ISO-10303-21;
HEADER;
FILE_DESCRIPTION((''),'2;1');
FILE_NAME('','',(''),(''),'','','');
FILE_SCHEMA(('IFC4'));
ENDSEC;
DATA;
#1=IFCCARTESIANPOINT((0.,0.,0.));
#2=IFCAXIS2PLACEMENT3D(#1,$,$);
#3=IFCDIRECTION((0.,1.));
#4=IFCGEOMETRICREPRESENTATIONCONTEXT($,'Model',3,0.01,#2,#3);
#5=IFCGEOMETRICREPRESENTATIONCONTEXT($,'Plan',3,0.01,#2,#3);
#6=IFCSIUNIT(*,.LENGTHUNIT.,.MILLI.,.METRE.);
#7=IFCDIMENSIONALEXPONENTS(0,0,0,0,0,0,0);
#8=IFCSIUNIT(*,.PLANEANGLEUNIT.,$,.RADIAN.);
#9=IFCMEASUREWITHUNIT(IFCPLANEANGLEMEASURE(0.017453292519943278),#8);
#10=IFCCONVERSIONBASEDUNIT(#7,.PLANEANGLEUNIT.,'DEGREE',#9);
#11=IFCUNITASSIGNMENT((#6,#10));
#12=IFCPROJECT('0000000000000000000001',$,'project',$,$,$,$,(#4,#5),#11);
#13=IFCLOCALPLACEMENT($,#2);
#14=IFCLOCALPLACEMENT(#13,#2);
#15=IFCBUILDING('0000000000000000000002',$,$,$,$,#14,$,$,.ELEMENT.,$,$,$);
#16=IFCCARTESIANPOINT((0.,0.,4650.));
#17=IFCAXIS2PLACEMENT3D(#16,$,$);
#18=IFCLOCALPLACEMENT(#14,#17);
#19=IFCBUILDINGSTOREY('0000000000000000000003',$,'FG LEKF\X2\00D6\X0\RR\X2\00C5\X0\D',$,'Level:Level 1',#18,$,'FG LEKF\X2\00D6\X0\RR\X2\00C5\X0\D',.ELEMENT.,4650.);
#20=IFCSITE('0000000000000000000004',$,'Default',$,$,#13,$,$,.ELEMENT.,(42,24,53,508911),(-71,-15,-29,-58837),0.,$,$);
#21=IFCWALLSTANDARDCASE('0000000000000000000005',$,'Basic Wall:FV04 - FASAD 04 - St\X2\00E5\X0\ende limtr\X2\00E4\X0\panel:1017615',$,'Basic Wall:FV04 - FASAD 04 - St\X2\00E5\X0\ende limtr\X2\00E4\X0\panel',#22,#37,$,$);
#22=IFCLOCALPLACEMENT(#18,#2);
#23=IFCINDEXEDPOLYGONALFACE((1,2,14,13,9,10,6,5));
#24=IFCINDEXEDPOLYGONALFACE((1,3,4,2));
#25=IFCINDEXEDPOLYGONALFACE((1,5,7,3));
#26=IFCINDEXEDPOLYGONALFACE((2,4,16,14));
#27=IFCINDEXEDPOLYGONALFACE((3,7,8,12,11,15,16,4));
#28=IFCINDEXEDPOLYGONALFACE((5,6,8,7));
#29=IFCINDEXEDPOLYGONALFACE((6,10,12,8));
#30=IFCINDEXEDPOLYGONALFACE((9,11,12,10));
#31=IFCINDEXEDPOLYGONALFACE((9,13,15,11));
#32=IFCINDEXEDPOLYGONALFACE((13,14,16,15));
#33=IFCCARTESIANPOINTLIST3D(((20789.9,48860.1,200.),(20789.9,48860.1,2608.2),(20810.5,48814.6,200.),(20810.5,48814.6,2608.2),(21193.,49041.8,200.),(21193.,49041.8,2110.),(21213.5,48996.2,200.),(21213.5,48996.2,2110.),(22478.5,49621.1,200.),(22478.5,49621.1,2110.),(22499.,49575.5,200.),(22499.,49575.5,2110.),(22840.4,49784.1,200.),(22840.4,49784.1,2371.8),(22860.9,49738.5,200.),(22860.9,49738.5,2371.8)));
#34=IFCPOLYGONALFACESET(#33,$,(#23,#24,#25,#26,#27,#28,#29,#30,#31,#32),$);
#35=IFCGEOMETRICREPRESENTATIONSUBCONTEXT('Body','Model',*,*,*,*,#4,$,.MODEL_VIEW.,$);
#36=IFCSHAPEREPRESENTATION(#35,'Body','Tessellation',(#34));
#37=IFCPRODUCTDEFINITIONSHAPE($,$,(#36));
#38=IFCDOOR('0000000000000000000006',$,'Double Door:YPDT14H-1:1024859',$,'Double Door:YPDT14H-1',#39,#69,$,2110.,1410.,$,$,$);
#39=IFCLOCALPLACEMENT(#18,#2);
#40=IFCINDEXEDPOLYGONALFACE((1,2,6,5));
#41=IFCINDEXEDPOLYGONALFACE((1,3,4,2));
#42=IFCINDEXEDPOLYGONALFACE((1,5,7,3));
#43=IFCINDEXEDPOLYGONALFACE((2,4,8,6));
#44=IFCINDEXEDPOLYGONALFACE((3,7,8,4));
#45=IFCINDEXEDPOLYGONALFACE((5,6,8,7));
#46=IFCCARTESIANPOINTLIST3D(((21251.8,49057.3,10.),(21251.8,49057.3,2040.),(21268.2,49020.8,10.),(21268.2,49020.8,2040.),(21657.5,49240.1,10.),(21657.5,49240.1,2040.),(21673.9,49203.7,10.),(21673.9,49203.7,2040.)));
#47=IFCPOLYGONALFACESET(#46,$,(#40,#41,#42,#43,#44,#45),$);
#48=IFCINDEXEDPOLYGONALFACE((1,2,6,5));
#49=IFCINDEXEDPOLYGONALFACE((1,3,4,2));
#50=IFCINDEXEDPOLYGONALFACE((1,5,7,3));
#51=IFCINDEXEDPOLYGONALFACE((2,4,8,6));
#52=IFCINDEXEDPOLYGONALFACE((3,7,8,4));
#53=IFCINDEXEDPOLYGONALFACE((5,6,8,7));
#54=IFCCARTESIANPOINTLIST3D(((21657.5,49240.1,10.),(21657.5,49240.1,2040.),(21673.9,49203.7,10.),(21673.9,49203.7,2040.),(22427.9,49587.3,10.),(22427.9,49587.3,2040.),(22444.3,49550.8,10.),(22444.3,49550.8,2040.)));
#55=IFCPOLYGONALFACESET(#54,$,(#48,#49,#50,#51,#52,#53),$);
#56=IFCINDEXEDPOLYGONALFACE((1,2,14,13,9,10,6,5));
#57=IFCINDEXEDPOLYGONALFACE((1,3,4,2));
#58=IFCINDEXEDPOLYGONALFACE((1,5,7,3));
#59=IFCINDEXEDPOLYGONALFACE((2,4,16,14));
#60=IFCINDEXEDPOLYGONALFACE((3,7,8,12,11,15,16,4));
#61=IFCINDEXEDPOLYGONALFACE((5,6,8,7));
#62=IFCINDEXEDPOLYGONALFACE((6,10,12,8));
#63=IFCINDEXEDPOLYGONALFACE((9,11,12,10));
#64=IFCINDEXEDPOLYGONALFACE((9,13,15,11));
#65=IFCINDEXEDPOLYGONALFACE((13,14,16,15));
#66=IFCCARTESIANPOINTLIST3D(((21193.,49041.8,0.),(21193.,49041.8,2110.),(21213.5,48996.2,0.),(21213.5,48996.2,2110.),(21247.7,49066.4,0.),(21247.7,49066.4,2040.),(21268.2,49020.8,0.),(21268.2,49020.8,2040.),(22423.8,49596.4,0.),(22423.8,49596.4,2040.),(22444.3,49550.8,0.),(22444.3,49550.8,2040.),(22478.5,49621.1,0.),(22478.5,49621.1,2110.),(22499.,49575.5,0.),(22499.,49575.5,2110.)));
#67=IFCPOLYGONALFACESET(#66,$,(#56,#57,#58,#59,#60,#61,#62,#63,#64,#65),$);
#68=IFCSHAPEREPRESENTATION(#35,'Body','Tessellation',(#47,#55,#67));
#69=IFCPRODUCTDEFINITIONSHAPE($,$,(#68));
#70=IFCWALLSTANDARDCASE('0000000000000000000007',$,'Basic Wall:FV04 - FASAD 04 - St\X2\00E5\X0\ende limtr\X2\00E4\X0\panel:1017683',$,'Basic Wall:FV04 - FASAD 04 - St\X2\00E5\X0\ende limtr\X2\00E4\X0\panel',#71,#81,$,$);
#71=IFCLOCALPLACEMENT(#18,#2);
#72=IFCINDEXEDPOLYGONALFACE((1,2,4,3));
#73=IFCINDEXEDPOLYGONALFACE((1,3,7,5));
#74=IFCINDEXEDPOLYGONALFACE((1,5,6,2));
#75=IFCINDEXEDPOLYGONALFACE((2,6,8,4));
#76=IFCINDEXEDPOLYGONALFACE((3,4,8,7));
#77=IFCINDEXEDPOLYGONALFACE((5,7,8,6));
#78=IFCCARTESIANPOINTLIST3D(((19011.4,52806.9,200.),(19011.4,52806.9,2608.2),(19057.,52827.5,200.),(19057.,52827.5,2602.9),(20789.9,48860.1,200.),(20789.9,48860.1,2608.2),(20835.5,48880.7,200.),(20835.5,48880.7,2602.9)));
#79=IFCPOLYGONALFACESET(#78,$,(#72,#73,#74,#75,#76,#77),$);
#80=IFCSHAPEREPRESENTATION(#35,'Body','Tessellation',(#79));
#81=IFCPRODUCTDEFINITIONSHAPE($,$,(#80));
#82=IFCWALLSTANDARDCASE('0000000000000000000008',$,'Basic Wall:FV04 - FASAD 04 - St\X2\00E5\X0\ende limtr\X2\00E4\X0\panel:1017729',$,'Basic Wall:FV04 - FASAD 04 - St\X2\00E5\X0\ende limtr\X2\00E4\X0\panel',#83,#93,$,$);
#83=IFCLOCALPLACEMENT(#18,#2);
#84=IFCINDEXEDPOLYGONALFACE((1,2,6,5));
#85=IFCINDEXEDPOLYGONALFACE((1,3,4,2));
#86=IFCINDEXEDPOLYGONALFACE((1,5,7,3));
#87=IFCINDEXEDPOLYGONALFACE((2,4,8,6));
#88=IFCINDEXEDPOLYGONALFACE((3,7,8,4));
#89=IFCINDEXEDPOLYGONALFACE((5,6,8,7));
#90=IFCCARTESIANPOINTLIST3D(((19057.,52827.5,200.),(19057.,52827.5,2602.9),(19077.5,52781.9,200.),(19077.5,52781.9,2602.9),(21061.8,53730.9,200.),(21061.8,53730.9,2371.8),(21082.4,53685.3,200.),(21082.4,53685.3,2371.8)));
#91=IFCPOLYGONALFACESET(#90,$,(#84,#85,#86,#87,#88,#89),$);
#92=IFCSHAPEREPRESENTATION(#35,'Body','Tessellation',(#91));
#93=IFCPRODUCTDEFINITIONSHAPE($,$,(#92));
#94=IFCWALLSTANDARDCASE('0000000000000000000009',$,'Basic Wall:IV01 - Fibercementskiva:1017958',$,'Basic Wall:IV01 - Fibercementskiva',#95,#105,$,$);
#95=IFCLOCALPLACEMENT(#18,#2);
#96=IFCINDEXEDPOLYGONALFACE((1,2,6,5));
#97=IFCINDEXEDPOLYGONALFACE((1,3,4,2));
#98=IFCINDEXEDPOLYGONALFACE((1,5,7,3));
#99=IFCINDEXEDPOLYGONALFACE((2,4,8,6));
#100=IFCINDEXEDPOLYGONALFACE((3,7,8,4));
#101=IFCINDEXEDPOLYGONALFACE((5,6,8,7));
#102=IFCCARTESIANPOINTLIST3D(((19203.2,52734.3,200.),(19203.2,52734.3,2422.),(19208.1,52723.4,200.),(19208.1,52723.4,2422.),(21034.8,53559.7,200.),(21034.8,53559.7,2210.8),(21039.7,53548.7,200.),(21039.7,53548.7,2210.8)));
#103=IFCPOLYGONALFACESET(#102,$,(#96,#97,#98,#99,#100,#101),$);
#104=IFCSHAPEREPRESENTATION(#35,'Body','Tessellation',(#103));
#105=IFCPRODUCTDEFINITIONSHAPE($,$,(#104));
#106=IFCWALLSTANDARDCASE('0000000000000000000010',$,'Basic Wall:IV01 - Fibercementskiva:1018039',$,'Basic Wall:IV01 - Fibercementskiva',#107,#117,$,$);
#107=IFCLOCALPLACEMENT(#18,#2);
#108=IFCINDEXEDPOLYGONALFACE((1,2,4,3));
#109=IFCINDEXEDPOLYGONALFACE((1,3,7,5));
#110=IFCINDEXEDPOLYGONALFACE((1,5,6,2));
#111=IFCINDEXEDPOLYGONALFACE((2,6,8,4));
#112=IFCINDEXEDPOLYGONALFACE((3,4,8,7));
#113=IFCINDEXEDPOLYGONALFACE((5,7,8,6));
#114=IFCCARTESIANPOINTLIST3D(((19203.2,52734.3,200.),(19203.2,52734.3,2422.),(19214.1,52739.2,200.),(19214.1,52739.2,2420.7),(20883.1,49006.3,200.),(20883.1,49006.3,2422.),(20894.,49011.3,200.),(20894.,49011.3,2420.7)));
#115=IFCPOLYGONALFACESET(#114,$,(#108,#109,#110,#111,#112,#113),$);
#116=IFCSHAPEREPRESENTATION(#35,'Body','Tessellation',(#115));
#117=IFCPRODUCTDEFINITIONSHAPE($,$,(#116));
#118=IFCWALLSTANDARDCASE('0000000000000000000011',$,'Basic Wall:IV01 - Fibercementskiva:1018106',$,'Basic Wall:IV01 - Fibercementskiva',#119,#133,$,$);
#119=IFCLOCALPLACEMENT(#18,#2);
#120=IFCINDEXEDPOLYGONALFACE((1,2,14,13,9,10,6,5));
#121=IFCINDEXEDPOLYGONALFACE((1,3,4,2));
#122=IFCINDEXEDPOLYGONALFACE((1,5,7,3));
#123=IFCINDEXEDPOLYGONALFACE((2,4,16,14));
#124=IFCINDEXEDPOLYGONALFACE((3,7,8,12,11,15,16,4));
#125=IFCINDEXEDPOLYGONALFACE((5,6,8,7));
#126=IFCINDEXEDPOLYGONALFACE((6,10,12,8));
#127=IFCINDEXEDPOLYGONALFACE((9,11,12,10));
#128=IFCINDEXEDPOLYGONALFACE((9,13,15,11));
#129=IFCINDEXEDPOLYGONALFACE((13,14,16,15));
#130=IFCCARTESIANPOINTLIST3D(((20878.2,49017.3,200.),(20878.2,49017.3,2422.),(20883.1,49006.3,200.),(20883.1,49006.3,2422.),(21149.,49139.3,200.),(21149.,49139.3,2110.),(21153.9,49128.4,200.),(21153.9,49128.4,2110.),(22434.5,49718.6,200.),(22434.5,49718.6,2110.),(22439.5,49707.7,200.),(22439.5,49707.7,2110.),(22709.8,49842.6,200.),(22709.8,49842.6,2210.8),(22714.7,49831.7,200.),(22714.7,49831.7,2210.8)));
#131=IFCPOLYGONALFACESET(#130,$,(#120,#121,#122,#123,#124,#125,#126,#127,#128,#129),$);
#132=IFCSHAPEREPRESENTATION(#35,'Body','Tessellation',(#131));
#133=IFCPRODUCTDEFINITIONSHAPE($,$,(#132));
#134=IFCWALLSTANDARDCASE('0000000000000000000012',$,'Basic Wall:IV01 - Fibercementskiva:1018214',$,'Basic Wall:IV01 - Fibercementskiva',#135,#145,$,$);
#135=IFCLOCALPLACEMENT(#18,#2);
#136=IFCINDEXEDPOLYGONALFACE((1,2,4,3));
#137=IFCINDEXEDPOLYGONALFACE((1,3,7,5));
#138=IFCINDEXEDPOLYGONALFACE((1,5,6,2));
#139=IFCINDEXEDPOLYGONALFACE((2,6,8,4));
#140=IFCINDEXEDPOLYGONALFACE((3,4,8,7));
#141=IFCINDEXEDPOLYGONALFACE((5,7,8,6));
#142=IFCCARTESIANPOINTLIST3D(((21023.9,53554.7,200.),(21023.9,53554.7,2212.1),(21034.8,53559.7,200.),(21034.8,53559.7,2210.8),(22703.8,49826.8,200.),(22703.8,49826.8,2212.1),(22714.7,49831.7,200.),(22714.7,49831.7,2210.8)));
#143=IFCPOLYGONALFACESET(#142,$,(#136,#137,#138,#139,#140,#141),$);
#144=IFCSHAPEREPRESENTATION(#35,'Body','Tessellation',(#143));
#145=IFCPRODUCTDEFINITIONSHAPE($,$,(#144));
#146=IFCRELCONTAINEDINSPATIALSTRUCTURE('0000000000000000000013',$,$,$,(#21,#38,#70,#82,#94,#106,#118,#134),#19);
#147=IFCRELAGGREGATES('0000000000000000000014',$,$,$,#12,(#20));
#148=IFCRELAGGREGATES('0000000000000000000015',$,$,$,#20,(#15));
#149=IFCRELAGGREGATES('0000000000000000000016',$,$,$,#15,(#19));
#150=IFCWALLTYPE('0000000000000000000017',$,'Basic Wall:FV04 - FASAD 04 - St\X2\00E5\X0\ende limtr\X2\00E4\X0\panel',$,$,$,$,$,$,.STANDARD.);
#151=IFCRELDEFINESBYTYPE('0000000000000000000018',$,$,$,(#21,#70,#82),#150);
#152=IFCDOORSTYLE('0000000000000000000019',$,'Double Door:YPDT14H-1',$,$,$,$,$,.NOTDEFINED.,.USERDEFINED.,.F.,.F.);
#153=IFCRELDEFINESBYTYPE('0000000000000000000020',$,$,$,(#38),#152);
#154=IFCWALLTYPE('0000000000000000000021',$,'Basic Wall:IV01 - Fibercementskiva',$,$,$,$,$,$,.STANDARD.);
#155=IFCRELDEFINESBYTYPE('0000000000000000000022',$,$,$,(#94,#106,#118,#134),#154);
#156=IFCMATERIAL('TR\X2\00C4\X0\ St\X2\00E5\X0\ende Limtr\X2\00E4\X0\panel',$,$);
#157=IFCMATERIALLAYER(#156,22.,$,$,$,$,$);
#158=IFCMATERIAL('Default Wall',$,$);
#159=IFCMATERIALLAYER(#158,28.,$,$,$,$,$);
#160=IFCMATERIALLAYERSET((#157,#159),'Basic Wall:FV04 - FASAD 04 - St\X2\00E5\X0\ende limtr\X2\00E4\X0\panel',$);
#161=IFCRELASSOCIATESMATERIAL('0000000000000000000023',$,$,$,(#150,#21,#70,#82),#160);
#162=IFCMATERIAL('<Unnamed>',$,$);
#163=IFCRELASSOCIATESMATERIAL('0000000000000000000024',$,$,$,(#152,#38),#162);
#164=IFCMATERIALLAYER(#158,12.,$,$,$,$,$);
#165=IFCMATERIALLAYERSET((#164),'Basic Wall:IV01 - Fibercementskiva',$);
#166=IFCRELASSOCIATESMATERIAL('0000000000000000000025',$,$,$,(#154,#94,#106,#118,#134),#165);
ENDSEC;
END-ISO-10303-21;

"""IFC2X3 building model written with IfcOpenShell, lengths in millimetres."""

from ifc_helpers import new_model, entity, si_unit, converted_unit, direction, frame, frame_2d, origin, origin_2d_with_axis, place, context, subcontext, project, spatial, polyline, rectangle, outline, extrude, clip, bounded_halfspace, source, transform, mapped, material, layer, layer_set, layer_usage, type_object, type_shapes, element, fill, save


model = new_model("IFC2X3")

# Units and contexts
model_context = context("Model", 3, precision=0.01, world=origin(), true_north=direction((0.0, 1.0)))
plan_context = context("Plan", 3, precision=0.01, world=origin(), true_north=direction((0.0, 1.0)))
body_context = subcontext(model_context, "Body", "Model", "MODEL_VIEW")
ifc_project = project(units=[si_unit("LENGTHUNIT", "METRE", prefix="MILLI"), converted_unit("PLANEANGLEUNIT", "DEGREE", entity("IfcPlaneAngleMeasure", 0.017453292519943278), si_unit("PLANEANGLEUNIT", "RADIAN"), dimensions=[0, 0, 0, 0, 0, 0, 0])], contexts=[model_context, plan_context])

# Site, building, storey
site_placement = place(None, origin())
site = spatial("IfcSite", under=ifc_project, at=site_placement, Name="Default", CompositionType="ELEMENT", RefLatitude=(42, 24, 53, 508911), RefLongitude=(-71, -15, -29, -58837), RefElevation=0.0)
building_placement = place(site_placement, origin())
building = spatial("IfcBuilding", under=site, at=building_placement, CompositionType="ELEMENT")
storey_placement = place(building_placement, frame((0.0, 0.0, 4650.0)))
storey = spatial("IfcBuildingStorey", under=building, at=storey_placement, Name="FG LEKFÖRRÅD", ObjectType="Level:Level 1", LongName="FG LEKFÖRRÅD", CompositionType="ELEMENT", Elevation=4650.0)

# Shared definitions
ifc_material_1 = material(Name="TRÄ Stående Limträpanel")
ifc_layer_1 = layer(ifc_material_1, 22.0)
ifc_material_2 = material(Name="Default Wall")
ifc_layer_2 = layer(ifc_material_2, 28.0)
ifc_layer_set_1 = layer_set([ifc_layer_1, ifc_layer_2], Name="Basic Wall:FV04 - FASAD 04 - Stående limträpanel")
wall_type_1 = type_object("IfcWallType", Name="Basic Wall:FV04 - FASAD 04 - Stående limträpanel", PredefinedType="STANDARD", material=ifc_layer_set_1)

# Wall, opening, door
ifc_layer_usage_1 = layer_usage(ifc_layer_set_1, "AXIS2", "NEGATIVE", 25.0)
wall_1_placement = place(storey_placement, frame((22850.6, 49761.3, 200.0), z_axis=(0.0, 0.0, 1.0), x_axis=(-0.911709, -0.410836, 0.0)))
wall_1 = element("IfcWallStandardCase", 1, at=wall_1_placement, inside=storey, type_object=wall_type_1, material=ifc_layer_usage_1, Name="Basic Wall:FV04 - FASAD 04 - Stående limträpanel:1017615", ObjectType="Basic Wall:FV04 - FASAD 04 - Stående limträpanel", context=body_context, shape_type="Clipping", body=[
    clip(extrude(rectangle(XDim=2249.0, YDim=50.0, at=frame_2d((1124.5, 0.0), x_axis=(1.0, 0.0))), origin(), (0.0, 0.0, 1.0), 2408.2), bounded_halfspace(frame((0.0, -25.0, 2171.8), z_axis=(-0.104528, 0.0, 0.994522), x_axis=(0.0, -1.0, 0.0)), False, frame((0.0, -25.0, 2171.8)), polyline([(0.0, 0.0), (2199.0, 0.0), (2249.0, 0.0), (2249.0, 50.0), (0.0, 50.0), (0.0, 0.0)]))),
])
opening_1_placement = place(wall_1_placement, frame((396.9, -25.0, -200.0)))
opening_1 = element("IfcOpeningElement", 2, at=opening_1_placement, cuts=wall_1, ObjectType="Opening", context=body_context, shape_type="SweptSolid", body=[
    extrude(rectangle(XDim=2110.0, YDim=1410.0, at=frame_2d((1055.0, 705.0), x_axis=(1.0, 0.0))), frame((0.0, 0.0, 0.0), z_axis=(0.0, 1.0, 0.0), x_axis=(0.0, 0.0, 1.0)), (0.0, 0.0, 1.0), 50.0),
])
ifc_material_3 = material(Name="<Unnamed>")
door_style = type_object("IfcDoorStyle", Name="Double Door:YPDT14H-1", ConstructionType="USERDEFINED", OperationType="NOTDEFINED", ParameterTakesPrecedence=False, Sizeable=False, material=ifc_material_3)
shared_shape = source(origin(), body_context, "Body", "SweptSolid", [
    extrude(rectangle(XDim=40.0, YDim=445.0, at=origin_2d_with_axis()), frame((1127.5, 30.0, 10.0), z_axis=(0.0, 0.0, 1.0), x_axis=(0.0, 1.0, 0.0)), (0.0, 0.0, 1.0), 2030.0),
    extrude(rectangle(XDim=845.0, YDim=40.0, at=origin_2d_with_axis()), frame((482.5, 30.0, 10.0)), (0.0, 0.0, 1.0), 2030.0),
    extrude(outline(polyline([(-1072.5, -705.0), (1037.5, -705.0), (1037.5, -645.0), (-1002.5, -645.0), (-1002.5, 645.0), (1037.5, 645.0), (1037.5, 705.0), (-1072.5, 705.0), (-1072.5, -705.0)])), frame((705.0, 50.0, 1037.5), z_axis=(0.0, -1.0, 0.0), x_axis=(0.0, 0.0, -1.0)), (0.0, 0.0, 1.0), 50.0),
])
type_shapes(door_style, [shared_shape])
door_placement = place(opening_1_placement, origin())
door = element("IfcDoor", 3, at=door_placement, inside=storey, type_object=door_style, material=ifc_material_3, Name="Double Door:YPDT14H-1:1024859", ObjectType="Double Door:YPDT14H-1", OverallHeight=2110.0, OverallWidth=1410.0, context=body_context, shape_type="MappedRepresentation", body=[
    mapped(shared_shape, transform((0.0, 0.0, 0.0), scale=1.0)),
])
fill(opening_1, door)

# Walls
ifc_layer_usage_2 = layer_usage(ifc_layer_set_1, "AXIS2", "NEGATIVE", 25.0)
wall_2_placement = place(storey_placement, frame((20812.7, 48870.4, 200.0), z_axis=(0.0, 0.0, 1.0), x_axis=(-0.410836, 0.911709, 0.0)))
element("IfcWallStandardCase", 4, at=wall_2_placement, inside=storey, type_object=wall_type_1, material=ifc_layer_usage_2, Name="Basic Wall:FV04 - FASAD 04 - Stående limträpanel:1017683", ObjectType="Basic Wall:FV04 - FASAD 04 - Stående limträpanel", context=body_context, shape_type="Clipping", body=[
    clip(extrude(rectangle(XDim=4329.0, YDim=50.0, at=frame_2d((2164.5, 0.0), x_axis=(-1.0, 0.0))), origin(), (0.0, 0.0, 1.0), 2408.2), bounded_halfspace(frame((0.0, -25.0, 2402.9), z_axis=(0.0, -0.104528, 0.994522), x_axis=(1.0, 0.0, 0.0)), False, frame((0.0, -25.0, 2402.9)), polyline([(0.0, 0.0), (4279.0, 0.0), (4329.0, 0.0), (4329.0, 50.0), (0.0, 50.0), (0.0, 0.0)]))),
])
ifc_layer_usage_3 = layer_usage(ifc_layer_set_1, "AXIS2", "NEGATIVE", 25.0)
wall_3_placement = place(storey_placement, frame((19067.3, 52804.7, 200.0), z_axis=(0.0, 0.0, 1.0), x_axis=(0.911709, 0.410836, 0.0)))
element("IfcWallStandardCase", 5, at=wall_3_placement, inside=storey, type_object=wall_type_1, material=ifc_layer_usage_3, Name="Basic Wall:FV04 - FASAD 04 - Stående limträpanel:1017729", ObjectType="Basic Wall:FV04 - FASAD 04 - Stående limträpanel", context=body_context, shape_type="Clipping", body=[
    clip(extrude(rectangle(XDim=2199.0, YDim=50.0, at=frame_2d((1099.5, 0.0), x_axis=(-1.0, 0.0))), origin(), (0.0, 0.0, 1.0), 2402.9), bounded_halfspace(frame((0.0, -25.0, 2402.9), z_axis=(0.104528, 0.0, 0.994522), x_axis=(0.0, 1.0, 0.0)), False, frame((0.0, -25.0, 2402.9)), polyline([(0.0, 0.0), (2199.0, 0.0), (2199.0, 50.0), (0.0, 50.0), (0.0, 0.0)]))),
])
ifc_layer_3 = layer(ifc_material_2, 12.0)
ifc_layer_set_2 = layer_set([ifc_layer_3], Name="Basic Wall:IV01 - Fibercementskiva")
ifc_layer_usage_4 = layer_usage(ifc_layer_set_2, "AXIS2", "NEGATIVE", 6.0)
wall_type_2 = type_object("IfcWallType", Name="Basic Wall:IV01 - Fibercementskiva", PredefinedType="STANDARD", material=ifc_layer_set_2)
wall_4_placement = place(storey_placement, frame((21037.3, 53554.2, 200.0), z_axis=(0.0, 0.0, 1.0), x_axis=(-0.911709, -0.410836, 0.0)))
element("IfcWallStandardCase", 6, at=wall_4_placement, inside=storey, type_object=wall_type_2, material=ifc_layer_usage_4, Name="Basic Wall:IV01 - Fibercementskiva:1017958", ObjectType="Basic Wall:IV01 - Fibercementskiva", context=body_context, shape_type="Clipping", body=[
    clip(extrude(rectangle(XDim=2009.0, YDim=12.0, at=frame_2d((1004.5, 0.0), x_axis=(-1.0, 0.0))), origin(), (0.0, 0.0, 1.0), 2222.0), bounded_halfspace(frame((0.0, -6.0, 2010.8), z_axis=(0.104528, 0.0, -0.994522), x_axis=(0.994522, 0.0, 0.104528)), True, frame((0.0, -6.0, 2010.8)), polyline([(0.0, 0.0), (2009.0, 0.0), (2009.0, 12.0), (0.0, 12.0), (0.0, 0.0)]))),
])
ifc_layer_usage_5 = layer_usage(ifc_layer_set_2, "AXIS2", "NEGATIVE", 6.0)
wall_5_placement = place(storey_placement, frame((19208.6, 52736.8, 200.0), z_axis=(0.0, 0.0, 1.0), x_axis=(0.410836, -0.911709, 0.0)))
element("IfcWallStandardCase", 7, at=wall_5_placement, inside=storey, type_object=wall_type_2, material=ifc_layer_usage_5, Name="Basic Wall:IV01 - Fibercementskiva:1018039", ObjectType="Basic Wall:IV01 - Fibercementskiva", context=body_context, shape_type="Clipping", body=[
    clip(extrude(rectangle(XDim=4089.0, YDim=12.0, at=frame_2d((2044.5, 0.0), x_axis=(-1.0, 0.0))), origin(), (0.0, 0.0, 1.0), 2222.0), bounded_halfspace(frame((0.0, -6.0, 2222.0), z_axis=(0.0, -0.104528, -0.994522), x_axis=(0.0, -0.994522, 0.104528)), True, frame((0.0, -6.0, 2222.0)), polyline([(0.0, 0.0), (4089.0, 0.0), (4089.0, 12.0), (0.0, 12.0), (0.0, 0.0)]))),
])

# Wall, opening
ifc_layer_usage_6 = layer_usage(ifc_layer_set_2, "AXIS2", "NEGATIVE", 6.0)
wall_6_placement = place(storey_placement, frame((20880.6, 49011.8, 200.0), z_axis=(0.0, 0.0, 1.0), x_axis=(0.911709, 0.410836, 0.0)))
wall_6 = element("IfcWallStandardCase", 8, at=wall_6_placement, inside=storey, type_object=wall_type_2, material=ifc_layer_usage_6, Name="Basic Wall:IV01 - Fibercementskiva:1018106", ObjectType="Basic Wall:IV01 - Fibercementskiva", context=body_context, shape_type="Clipping", body=[
    clip(extrude(rectangle(XDim=2009.0, YDim=12.0, at=frame_2d((1004.5, 0.0), x_axis=(1.0, 0.0))), origin(), (0.0, 0.0, 1.0), 2222.0), bounded_halfspace(frame((0.0, -6.0, 2222.0), z_axis=(-0.104528, 0.0, -0.994522), x_axis=(-0.994522, 0.0, 0.104528)), True, frame((0.0, -6.0, 2222.0)), polyline([(0.0, 0.0), (2009.0, 0.0), (2009.0, 12.0), (0.0, 12.0), (0.0, 0.0)]))),
])
opening_2_placement = place(wall_6_placement, origin())
element("IfcOpeningElement", 9, at=opening_2_placement, cuts=wall_6, ObjectType="Opening", context=body_context, shape_type="SweptSolid", body=[
    extrude(rectangle(XDim=2110.0, YDim=1410.0, at=frame_2d((0.0, 0.0), x_axis=(0.0, 1.0))), frame((1002.1, -1625.0, 855.0), z_axis=(0.0, 1.0, 0.0), x_axis=(-1.0, 0.0, 0.0)), (0.0, 0.0, 1.0), 3048.0),
])

# Wall
ifc_layer_usage_7 = layer_usage(ifc_layer_set_2, "AXIS2", "NEGATIVE", 6.0)
wall_7_placement = place(storey_placement, frame((22709.2, 49829.2, 200.0), z_axis=(0.0, 0.0, 1.0), x_axis=(-0.410836, 0.911709, 0.0)))
element("IfcWallStandardCase", 10, at=wall_7_placement, inside=storey, type_object=wall_type_2, material=ifc_layer_usage_7, Name="Basic Wall:IV01 - Fibercementskiva:1018214", ObjectType="Basic Wall:IV01 - Fibercementskiva", context=body_context, shape_type="Clipping", body=[
    clip(extrude(rectangle(XDim=4089.0, YDim=12.0, at=frame_2d((2044.5, 0.0), x_axis=(-1.0, 0.0))), origin(), (0.0, 0.0, 1.0), 2012.1), bounded_halfspace(frame((0.0, -6.0, 2010.8), z_axis=(0.0, 0.104528, -0.994522), x_axis=(0.0, 0.994522, 0.104528)), True, frame((0.0, -6.0, 2010.8)), polyline([(0.0, 0.0), (4089.0, 0.0), (4089.0, 12.0), (0.0, 12.0), (0.0, 0.0)]))),
])

save(model, "model.ifc")
